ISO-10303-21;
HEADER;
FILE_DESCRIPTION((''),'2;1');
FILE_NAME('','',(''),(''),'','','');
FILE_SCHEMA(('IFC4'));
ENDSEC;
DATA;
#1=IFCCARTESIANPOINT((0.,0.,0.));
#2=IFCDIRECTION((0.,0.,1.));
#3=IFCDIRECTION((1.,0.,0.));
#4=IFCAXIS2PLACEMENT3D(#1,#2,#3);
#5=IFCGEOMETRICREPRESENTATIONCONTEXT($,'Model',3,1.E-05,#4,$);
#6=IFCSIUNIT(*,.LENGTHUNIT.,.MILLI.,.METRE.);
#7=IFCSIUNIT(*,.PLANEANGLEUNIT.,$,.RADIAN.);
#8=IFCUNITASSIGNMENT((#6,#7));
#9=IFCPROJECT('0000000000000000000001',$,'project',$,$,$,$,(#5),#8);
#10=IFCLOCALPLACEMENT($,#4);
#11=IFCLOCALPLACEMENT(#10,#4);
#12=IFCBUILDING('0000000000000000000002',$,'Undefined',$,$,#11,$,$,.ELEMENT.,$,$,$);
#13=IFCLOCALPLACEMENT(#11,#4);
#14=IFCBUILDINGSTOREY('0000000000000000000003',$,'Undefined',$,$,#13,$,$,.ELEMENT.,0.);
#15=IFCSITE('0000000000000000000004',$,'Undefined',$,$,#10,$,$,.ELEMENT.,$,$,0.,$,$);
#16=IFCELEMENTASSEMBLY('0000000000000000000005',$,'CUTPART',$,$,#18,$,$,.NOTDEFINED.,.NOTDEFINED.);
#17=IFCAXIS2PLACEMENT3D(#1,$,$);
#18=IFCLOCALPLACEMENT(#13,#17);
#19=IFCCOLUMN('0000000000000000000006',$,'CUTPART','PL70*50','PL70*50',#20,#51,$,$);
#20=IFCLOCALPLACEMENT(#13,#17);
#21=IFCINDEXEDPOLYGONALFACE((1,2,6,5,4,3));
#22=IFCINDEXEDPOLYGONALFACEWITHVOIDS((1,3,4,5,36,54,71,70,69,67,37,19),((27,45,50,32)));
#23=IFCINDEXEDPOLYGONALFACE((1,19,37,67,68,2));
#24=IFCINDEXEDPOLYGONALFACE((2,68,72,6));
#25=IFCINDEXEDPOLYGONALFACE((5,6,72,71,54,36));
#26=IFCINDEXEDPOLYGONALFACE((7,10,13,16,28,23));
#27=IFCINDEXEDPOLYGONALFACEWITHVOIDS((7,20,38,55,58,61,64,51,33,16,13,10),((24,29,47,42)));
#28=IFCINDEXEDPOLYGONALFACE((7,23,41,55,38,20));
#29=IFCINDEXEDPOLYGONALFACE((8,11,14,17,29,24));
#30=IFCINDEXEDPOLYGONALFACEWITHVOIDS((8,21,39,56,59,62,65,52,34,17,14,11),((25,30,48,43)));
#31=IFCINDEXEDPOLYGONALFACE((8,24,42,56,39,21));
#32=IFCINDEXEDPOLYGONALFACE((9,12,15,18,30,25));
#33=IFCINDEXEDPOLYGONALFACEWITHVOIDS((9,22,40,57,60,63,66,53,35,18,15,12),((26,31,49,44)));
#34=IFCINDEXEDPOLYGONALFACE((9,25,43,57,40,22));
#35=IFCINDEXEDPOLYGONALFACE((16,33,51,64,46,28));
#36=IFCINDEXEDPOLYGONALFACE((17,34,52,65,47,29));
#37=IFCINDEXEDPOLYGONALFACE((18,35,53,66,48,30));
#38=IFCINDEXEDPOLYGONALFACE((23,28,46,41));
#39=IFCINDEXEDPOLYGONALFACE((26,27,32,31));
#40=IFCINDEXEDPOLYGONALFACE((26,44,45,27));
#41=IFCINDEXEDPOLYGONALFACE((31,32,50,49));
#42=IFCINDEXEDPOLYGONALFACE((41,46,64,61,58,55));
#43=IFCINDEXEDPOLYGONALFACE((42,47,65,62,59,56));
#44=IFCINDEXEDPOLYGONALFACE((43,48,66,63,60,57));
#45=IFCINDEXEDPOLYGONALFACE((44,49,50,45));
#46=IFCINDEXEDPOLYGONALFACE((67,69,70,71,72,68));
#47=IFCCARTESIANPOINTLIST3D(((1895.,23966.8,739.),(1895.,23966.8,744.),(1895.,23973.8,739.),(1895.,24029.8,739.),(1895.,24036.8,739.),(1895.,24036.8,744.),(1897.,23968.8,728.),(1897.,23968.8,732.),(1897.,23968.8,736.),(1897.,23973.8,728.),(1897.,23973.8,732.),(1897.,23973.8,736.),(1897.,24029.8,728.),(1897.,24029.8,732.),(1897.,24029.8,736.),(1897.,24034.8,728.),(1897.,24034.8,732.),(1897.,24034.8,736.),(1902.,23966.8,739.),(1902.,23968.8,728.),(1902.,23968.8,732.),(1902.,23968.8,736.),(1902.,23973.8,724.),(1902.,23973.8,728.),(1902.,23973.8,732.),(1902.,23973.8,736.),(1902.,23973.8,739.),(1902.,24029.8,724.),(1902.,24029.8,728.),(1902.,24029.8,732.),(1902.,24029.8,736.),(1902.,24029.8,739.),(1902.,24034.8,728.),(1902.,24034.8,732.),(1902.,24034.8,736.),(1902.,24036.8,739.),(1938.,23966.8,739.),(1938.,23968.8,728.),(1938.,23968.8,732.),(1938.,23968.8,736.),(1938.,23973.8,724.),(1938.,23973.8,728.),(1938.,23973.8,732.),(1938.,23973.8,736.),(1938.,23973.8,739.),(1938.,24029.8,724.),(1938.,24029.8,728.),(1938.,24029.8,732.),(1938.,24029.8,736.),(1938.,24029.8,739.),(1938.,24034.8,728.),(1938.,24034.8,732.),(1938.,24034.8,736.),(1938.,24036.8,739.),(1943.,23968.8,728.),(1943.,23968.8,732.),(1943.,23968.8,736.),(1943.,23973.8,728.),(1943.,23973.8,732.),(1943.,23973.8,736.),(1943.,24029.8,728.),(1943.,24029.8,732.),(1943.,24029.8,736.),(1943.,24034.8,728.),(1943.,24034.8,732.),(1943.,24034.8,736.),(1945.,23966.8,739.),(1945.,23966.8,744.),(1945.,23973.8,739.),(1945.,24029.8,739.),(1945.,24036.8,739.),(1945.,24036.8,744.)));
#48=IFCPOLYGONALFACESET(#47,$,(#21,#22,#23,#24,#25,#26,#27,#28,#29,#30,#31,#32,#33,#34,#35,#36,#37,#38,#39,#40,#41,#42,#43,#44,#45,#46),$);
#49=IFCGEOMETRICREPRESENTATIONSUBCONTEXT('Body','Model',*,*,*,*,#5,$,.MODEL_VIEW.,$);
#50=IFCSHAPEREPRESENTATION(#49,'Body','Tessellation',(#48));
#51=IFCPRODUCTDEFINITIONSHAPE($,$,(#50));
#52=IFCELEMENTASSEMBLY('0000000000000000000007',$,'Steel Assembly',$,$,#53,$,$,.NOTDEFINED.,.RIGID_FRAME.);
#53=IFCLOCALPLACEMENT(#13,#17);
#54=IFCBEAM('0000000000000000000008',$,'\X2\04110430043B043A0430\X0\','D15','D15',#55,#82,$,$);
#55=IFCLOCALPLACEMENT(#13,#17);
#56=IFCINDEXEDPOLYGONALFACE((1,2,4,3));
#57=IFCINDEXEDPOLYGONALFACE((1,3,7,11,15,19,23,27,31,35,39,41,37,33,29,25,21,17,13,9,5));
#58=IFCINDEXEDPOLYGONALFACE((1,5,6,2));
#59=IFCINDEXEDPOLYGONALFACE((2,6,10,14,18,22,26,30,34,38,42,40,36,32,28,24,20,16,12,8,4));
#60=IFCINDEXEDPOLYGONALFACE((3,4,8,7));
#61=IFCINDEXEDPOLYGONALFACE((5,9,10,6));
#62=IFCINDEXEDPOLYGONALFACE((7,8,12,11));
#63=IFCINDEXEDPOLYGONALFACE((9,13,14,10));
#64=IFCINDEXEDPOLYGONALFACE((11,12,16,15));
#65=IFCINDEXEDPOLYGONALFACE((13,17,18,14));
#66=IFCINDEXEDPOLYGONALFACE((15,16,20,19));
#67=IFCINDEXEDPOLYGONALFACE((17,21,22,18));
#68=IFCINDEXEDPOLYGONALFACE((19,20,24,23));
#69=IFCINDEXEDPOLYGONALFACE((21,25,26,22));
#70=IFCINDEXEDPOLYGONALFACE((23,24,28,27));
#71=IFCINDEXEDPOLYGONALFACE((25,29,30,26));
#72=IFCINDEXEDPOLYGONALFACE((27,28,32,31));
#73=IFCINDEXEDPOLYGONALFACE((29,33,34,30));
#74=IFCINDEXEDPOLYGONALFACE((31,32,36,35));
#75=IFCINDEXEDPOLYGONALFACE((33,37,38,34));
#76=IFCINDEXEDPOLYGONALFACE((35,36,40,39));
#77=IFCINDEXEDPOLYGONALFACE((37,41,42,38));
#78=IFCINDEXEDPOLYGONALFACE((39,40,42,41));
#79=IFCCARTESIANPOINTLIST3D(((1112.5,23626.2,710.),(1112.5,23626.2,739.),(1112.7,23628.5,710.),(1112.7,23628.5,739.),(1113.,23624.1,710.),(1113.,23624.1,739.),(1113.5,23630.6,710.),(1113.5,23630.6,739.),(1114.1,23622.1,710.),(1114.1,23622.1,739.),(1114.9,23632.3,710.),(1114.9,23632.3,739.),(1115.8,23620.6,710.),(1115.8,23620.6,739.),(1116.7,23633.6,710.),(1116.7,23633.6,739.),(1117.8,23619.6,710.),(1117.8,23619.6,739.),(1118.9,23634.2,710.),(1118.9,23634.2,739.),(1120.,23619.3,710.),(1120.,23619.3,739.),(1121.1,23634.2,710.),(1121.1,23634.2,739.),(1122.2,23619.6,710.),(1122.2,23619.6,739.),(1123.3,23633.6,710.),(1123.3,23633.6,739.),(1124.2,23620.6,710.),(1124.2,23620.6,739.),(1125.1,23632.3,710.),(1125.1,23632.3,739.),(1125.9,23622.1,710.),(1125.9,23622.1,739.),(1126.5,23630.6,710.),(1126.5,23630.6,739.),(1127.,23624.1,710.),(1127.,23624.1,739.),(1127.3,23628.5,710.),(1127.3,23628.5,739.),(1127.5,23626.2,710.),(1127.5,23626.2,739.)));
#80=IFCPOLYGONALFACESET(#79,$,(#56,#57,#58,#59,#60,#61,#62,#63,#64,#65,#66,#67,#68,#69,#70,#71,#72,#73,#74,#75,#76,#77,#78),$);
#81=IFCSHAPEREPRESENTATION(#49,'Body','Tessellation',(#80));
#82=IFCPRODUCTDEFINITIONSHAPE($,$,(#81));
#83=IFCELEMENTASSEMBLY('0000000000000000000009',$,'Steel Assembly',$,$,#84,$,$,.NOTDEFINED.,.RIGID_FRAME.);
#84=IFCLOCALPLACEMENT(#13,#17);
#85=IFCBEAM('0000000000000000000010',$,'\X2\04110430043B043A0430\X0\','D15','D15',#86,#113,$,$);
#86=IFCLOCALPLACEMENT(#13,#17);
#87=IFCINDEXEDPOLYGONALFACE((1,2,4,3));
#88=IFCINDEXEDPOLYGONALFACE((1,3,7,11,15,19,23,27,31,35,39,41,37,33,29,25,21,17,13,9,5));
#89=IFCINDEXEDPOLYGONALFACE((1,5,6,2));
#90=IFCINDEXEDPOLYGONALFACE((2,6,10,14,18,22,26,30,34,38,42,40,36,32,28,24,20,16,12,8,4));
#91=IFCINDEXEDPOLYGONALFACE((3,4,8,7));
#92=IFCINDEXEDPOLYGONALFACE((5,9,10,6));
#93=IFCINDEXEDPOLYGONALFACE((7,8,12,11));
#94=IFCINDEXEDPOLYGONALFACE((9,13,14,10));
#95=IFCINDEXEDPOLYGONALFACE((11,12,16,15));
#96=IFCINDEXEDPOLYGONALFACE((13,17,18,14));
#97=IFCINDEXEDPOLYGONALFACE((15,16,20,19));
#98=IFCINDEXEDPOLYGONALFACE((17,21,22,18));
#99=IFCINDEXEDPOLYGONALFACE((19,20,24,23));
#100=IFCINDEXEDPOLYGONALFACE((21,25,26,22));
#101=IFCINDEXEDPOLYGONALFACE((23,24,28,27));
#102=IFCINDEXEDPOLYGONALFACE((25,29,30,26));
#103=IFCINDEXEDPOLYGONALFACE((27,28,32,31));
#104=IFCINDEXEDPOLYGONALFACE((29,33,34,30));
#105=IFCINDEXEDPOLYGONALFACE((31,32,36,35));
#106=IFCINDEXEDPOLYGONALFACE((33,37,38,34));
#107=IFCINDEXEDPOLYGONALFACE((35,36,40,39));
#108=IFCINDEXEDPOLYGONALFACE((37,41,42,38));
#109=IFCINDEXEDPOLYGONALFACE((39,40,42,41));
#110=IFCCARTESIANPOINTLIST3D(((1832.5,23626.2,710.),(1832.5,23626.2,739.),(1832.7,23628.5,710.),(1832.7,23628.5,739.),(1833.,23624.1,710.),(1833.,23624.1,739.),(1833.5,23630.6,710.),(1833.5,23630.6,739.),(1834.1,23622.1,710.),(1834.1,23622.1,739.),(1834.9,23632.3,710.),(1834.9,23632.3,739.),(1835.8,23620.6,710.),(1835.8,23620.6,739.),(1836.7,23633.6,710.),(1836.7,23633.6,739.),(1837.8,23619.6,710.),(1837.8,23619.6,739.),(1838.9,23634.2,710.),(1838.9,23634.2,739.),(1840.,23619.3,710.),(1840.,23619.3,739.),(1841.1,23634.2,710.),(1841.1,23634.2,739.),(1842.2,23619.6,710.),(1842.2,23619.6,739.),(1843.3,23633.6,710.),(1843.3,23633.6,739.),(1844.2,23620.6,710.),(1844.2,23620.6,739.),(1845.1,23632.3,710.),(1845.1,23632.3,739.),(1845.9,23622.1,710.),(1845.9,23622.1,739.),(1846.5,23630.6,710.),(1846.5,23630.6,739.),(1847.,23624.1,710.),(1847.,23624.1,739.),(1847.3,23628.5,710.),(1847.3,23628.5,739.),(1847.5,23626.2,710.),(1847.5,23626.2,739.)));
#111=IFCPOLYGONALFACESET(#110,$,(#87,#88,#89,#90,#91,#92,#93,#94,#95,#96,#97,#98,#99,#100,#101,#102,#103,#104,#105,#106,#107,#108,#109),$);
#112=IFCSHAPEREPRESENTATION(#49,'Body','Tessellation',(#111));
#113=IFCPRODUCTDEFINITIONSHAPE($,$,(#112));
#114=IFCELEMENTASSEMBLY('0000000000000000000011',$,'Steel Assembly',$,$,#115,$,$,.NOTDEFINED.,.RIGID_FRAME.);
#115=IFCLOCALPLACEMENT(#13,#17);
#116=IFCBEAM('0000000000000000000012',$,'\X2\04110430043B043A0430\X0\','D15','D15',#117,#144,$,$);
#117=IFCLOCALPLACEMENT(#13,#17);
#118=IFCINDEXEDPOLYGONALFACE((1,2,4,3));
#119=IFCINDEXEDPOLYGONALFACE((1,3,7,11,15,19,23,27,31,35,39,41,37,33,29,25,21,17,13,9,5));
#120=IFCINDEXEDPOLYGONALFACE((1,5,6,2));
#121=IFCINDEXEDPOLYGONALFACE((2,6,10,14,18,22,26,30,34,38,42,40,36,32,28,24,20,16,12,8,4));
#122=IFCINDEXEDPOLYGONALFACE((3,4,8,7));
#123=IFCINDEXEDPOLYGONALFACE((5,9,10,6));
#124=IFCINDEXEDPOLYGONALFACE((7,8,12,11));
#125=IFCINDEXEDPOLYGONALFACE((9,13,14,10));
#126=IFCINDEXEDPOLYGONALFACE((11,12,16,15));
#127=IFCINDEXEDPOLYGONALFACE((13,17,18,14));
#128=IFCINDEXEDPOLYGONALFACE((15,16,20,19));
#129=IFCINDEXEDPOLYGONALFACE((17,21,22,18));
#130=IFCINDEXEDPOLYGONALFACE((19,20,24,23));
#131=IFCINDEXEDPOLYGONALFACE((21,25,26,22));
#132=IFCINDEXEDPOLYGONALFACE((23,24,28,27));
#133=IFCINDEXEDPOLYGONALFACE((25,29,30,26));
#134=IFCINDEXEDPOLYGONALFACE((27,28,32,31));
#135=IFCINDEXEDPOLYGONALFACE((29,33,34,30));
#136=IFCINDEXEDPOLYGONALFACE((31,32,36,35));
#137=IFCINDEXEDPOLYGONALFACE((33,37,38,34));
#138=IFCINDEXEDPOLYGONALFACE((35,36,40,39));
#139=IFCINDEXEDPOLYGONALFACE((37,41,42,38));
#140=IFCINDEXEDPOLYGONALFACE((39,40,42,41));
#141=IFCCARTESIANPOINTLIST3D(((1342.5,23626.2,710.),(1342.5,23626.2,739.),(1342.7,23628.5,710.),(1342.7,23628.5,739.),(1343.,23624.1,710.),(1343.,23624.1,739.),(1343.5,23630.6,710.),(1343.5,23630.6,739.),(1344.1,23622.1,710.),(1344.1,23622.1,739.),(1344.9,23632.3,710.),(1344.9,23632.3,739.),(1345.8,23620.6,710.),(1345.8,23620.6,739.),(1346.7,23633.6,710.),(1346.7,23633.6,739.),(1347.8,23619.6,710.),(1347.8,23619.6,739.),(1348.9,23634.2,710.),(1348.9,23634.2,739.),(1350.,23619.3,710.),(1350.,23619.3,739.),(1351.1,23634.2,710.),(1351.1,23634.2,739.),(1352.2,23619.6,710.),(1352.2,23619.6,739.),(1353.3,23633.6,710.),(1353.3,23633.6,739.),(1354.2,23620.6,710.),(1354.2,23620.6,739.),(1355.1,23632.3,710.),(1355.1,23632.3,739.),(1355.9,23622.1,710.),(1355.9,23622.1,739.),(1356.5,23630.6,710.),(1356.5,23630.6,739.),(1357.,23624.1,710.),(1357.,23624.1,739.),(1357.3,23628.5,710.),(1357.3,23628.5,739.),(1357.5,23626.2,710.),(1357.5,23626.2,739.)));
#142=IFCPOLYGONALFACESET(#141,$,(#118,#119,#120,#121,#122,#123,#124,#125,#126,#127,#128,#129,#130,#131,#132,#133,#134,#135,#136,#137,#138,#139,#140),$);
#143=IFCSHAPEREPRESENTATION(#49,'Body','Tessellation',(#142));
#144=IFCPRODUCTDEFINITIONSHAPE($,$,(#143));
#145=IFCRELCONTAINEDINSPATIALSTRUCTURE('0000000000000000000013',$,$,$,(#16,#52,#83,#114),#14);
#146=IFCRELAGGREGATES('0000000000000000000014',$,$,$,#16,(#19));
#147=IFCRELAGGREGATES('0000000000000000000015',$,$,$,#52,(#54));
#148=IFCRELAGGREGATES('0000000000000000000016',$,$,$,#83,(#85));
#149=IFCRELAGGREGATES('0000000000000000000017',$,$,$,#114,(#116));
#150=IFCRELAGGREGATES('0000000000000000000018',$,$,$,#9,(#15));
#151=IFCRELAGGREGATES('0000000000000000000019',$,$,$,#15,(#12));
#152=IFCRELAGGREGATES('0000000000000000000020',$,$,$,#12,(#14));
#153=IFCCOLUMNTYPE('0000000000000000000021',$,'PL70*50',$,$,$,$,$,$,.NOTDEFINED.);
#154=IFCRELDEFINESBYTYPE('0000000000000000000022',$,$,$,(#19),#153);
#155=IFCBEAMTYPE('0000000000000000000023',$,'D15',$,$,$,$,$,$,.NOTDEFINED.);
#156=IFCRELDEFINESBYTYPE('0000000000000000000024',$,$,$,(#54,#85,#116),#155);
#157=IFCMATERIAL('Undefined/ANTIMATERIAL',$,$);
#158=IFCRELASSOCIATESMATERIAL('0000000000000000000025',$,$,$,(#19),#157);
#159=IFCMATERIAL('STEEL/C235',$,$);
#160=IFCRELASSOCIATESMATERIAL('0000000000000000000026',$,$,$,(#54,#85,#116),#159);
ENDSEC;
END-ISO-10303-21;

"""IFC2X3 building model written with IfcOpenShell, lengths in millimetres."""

from ifc_helpers import new_model, si_unit, frame, origin_with_axes, origin_2d_with_axis, place, context, subcontext, project, spatial, polyline, rectangle, circle, outline, extrude, boolean, material, type_object, element, aggregate, save


model = new_model("IFC2X3")

# Units and contexts
model_context = context("Model", 3, precision=1e-05, world=origin_with_axes())
body_context = subcontext(model_context, "Body", "Model", "MODEL_VIEW")
ifc_project = project(units=[si_unit("LENGTHUNIT", "METRE", prefix="MILLI"), si_unit("PLANEANGLEUNIT", "RADIAN")], contexts=[model_context])

# Site, building, storey
site_placement = place(None, origin_with_axes())
site = spatial("IfcSite", under=ifc_project, at=site_placement, Name="Undefined", CompositionType="ELEMENT", RefElevation=0.0)
building_placement = place(site_placement, origin_with_axes())
building = spatial("IfcBuilding", under=site, at=building_placement, Name="Undefined", CompositionType="ELEMENT")
storey_placement = place(building_placement, origin_with_axes())
storey = spatial("IfcBuildingStorey", under=building, at=storey_placement, Name="Undefined", CompositionType="ELEMENT", Elevation=0.0)

# Element assembly, column
assembly_1_placement = place(storey_placement, origin_with_axes())
assembly_1 = element("IfcElementAssembly", 1, at=assembly_1_placement, inside=storey, Name="CUTPART", AssemblyPlace="NOTDEFINED", PredefinedType="NOTDEFINED")
ifc_material_1 = material(Name="Undefined/ANTIMATERIAL")
column_type = type_object("IfcColumnType", Name="PL70*50", PredefinedType="NOTDEFINED")
column_placement = place(assembly_1_placement, frame((1920.0, 24001.8, 724.0), z_axis=(0.0, 0.0, 1.0), x_axis=(0.0, -1.0, 0.0)))
column = element("IfcColumn", 2, at=column_placement, type_object=column_type, material=ifc_material_1, Name="CUTPART", Description="PL70*50", ObjectType="PL70*50", context=body_context, shape_type="CSG", body=[
    boolean("DIFFERENCE", boolean("DIFFERENCE", boolean("DIFFERENCE", boolean("DIFFERENCE", extrude(rectangle(XDim=50.0, YDim=70.0, at=origin_2d_with_axis()), frame((0.0, 0.0, 20.0), z_axis=(0.0, 0.0, -1.0), x_axis=(0.0, 1.0, 0.0)), (0.0, 0.0, 1.0), 20.0), extrude(outline(polyline([(0.0, 0.0), (15.0, 0.0), (15.0, 7.0), (11.0, 2.0), (11.0, 7.0), (7.0, 2.0), (7.0, 7.0), (3.0, 2.0), (3.0, 7.0), (0.0, 7.0), (0.0, 0.0)])), frame((-35.0, 40.0, 15.0), z_axis=(0.0, -1.0, 0.0), x_axis=(0.0, 0.0, -1.0)), (0.0, 0.0, 1.0), 80.0)), extrude(outline(polyline([(0.0, 0.0), (15.0, 0.0), (15.0, 7.0), (11.0, 2.0), (11.0, 7.0), (7.0, 2.0), (7.0, 7.0), (3.0, 2.0), (3.0, 7.0), (0.0, 7.0), (0.0, 0.0)])), frame((35.0, -40.0, 15.0), z_axis=(0.0, 1.0, 0.0), x_axis=(0.0, 0.0, -1.0)), (0.0, 0.0, 1.0), 80.0)), extrude(outline(polyline([(0.0, 0.0), (15.0, 0.0), (15.0, 7.0), (11.0, 2.0), (11.0, 7.0), (7.0, 2.0), (7.0, 7.0), (3.0, 2.0), (3.0, 7.0), (0.0, 7.0), (0.0, 0.0)])), frame((40.0, 25.0, 15.0), z_axis=(-1.0, 0.0, 0.0), x_axis=(0.0, 0.0, -1.0)), (0.0, 0.0, 1.0), 80.0)), extrude(outline(polyline([(0.0, 0.0), (15.0, 0.0), (15.0, 7.0), (11.0, 2.0), (11.0, 7.0), (7.0, 2.0), (7.0, 7.0), (3.0, 2.0), (3.0, 7.0), (0.0, 7.0), (0.0, 0.0)])), frame((-40.0, -25.0, 15.0), z_axis=(1.0, 0.0, 0.0), x_axis=(0.0, 0.0, -1.0)), (0.0, 0.0, 1.0), 80.0)),
])
aggregate(assembly_1, [column])

# Element assemblies, beams
assembly_2_placement = place(storey_placement, origin_with_axes())
assembly_2 = element("IfcElementAssembly", 3, at=assembly_2_placement, inside=storey, Name="Steel Assembly", AssemblyPlace="NOTDEFINED", PredefinedType="RIGID_FRAME")
ifc_material_2 = material(Name="STEEL/C235")
beam_type_1 = type_object("IfcBeamType", Name="D15", PredefinedType="NOTDEFINED")
beam_1_placement = place(assembly_2_placement, frame((1120.0, 23626.8, 739.0), z_axis=(1.0, 0.0, 0.0), x_axis=(0.0, 0.0, -1.0)))
beam_1 = element("IfcBeam", 4, at=beam_1_placement, type_object=beam_type_1, material=ifc_material_2, Name="Балка", Description="D15", ObjectType="D15", context=body_context, shape_type="SweptSolid", body=[
    extrude(circle(Radius=7.5, at=origin_2d_with_axis()), frame((29.0, 0.0, 0.0), z_axis=(-1.0, 0.0, 0.0), x_axis=(0.0, -1.0, 0.0)), (0.0, 0.0, 1.0), 29.0),
])
aggregate(assembly_2, [beam_1])
assembly_3_placement = place(storey_placement, origin_with_axes())
assembly_3 = element("IfcElementAssembly", 5, at=assembly_3_placement, inside=storey, Name="Steel Assembly", AssemblyPlace="NOTDEFINED", PredefinedType="RIGID_FRAME")
beam_2_placement = place(assembly_3_placement, frame((1840.0, 23626.8, 739.0), z_axis=(1.0, 0.0, 0.0), x_axis=(0.0, 0.0, -1.0)))
beam_2 = element("IfcBeam", 6, at=beam_2_placement, type_object=beam_type_1, material=ifc_material_2, Name="Балка", Description="D15", ObjectType="D15", context=body_context, shape_type="SweptSolid", body=[
    extrude(circle(Radius=7.5, at=origin_2d_with_axis()), frame((29.0, 0.0, 0.0), z_axis=(-1.0, 0.0, 0.0), x_axis=(0.0, -1.0, 0.0)), (0.0, 0.0, 1.0), 29.0),
])
aggregate(assembly_3, [beam_2])
assembly_4_placement = place(storey_placement, origin_with_axes())
assembly_4 = element("IfcElementAssembly", 7, at=assembly_4_placement, inside=storey, Name="Steel Assembly", AssemblyPlace="NOTDEFINED", PredefinedType="RIGID_FRAME")
beam_3_placement = place(assembly_4_placement, frame((1350.0, 23626.8, 739.0), z_axis=(1.0, 0.0, 0.0), x_axis=(0.0, 0.0, -1.0)))
beam_3 = element("IfcBeam", 8, at=beam_3_placement, type_object=beam_type_1, material=ifc_material_2, Name="Балка", Description="D15", ObjectType="D15", context=body_context, shape_type="SweptSolid", body=[
    extrude(circle(Radius=7.5, at=origin_2d_with_axis()), frame((29.0, 0.0, 0.0), z_axis=(-1.0, 0.0, 0.0), x_axis=(0.0, -1.0, 0.0)), (0.0, 0.0, 1.0), 29.0),
])
aggregate(assembly_4, [beam_3])

save(model, "model.ifc")
